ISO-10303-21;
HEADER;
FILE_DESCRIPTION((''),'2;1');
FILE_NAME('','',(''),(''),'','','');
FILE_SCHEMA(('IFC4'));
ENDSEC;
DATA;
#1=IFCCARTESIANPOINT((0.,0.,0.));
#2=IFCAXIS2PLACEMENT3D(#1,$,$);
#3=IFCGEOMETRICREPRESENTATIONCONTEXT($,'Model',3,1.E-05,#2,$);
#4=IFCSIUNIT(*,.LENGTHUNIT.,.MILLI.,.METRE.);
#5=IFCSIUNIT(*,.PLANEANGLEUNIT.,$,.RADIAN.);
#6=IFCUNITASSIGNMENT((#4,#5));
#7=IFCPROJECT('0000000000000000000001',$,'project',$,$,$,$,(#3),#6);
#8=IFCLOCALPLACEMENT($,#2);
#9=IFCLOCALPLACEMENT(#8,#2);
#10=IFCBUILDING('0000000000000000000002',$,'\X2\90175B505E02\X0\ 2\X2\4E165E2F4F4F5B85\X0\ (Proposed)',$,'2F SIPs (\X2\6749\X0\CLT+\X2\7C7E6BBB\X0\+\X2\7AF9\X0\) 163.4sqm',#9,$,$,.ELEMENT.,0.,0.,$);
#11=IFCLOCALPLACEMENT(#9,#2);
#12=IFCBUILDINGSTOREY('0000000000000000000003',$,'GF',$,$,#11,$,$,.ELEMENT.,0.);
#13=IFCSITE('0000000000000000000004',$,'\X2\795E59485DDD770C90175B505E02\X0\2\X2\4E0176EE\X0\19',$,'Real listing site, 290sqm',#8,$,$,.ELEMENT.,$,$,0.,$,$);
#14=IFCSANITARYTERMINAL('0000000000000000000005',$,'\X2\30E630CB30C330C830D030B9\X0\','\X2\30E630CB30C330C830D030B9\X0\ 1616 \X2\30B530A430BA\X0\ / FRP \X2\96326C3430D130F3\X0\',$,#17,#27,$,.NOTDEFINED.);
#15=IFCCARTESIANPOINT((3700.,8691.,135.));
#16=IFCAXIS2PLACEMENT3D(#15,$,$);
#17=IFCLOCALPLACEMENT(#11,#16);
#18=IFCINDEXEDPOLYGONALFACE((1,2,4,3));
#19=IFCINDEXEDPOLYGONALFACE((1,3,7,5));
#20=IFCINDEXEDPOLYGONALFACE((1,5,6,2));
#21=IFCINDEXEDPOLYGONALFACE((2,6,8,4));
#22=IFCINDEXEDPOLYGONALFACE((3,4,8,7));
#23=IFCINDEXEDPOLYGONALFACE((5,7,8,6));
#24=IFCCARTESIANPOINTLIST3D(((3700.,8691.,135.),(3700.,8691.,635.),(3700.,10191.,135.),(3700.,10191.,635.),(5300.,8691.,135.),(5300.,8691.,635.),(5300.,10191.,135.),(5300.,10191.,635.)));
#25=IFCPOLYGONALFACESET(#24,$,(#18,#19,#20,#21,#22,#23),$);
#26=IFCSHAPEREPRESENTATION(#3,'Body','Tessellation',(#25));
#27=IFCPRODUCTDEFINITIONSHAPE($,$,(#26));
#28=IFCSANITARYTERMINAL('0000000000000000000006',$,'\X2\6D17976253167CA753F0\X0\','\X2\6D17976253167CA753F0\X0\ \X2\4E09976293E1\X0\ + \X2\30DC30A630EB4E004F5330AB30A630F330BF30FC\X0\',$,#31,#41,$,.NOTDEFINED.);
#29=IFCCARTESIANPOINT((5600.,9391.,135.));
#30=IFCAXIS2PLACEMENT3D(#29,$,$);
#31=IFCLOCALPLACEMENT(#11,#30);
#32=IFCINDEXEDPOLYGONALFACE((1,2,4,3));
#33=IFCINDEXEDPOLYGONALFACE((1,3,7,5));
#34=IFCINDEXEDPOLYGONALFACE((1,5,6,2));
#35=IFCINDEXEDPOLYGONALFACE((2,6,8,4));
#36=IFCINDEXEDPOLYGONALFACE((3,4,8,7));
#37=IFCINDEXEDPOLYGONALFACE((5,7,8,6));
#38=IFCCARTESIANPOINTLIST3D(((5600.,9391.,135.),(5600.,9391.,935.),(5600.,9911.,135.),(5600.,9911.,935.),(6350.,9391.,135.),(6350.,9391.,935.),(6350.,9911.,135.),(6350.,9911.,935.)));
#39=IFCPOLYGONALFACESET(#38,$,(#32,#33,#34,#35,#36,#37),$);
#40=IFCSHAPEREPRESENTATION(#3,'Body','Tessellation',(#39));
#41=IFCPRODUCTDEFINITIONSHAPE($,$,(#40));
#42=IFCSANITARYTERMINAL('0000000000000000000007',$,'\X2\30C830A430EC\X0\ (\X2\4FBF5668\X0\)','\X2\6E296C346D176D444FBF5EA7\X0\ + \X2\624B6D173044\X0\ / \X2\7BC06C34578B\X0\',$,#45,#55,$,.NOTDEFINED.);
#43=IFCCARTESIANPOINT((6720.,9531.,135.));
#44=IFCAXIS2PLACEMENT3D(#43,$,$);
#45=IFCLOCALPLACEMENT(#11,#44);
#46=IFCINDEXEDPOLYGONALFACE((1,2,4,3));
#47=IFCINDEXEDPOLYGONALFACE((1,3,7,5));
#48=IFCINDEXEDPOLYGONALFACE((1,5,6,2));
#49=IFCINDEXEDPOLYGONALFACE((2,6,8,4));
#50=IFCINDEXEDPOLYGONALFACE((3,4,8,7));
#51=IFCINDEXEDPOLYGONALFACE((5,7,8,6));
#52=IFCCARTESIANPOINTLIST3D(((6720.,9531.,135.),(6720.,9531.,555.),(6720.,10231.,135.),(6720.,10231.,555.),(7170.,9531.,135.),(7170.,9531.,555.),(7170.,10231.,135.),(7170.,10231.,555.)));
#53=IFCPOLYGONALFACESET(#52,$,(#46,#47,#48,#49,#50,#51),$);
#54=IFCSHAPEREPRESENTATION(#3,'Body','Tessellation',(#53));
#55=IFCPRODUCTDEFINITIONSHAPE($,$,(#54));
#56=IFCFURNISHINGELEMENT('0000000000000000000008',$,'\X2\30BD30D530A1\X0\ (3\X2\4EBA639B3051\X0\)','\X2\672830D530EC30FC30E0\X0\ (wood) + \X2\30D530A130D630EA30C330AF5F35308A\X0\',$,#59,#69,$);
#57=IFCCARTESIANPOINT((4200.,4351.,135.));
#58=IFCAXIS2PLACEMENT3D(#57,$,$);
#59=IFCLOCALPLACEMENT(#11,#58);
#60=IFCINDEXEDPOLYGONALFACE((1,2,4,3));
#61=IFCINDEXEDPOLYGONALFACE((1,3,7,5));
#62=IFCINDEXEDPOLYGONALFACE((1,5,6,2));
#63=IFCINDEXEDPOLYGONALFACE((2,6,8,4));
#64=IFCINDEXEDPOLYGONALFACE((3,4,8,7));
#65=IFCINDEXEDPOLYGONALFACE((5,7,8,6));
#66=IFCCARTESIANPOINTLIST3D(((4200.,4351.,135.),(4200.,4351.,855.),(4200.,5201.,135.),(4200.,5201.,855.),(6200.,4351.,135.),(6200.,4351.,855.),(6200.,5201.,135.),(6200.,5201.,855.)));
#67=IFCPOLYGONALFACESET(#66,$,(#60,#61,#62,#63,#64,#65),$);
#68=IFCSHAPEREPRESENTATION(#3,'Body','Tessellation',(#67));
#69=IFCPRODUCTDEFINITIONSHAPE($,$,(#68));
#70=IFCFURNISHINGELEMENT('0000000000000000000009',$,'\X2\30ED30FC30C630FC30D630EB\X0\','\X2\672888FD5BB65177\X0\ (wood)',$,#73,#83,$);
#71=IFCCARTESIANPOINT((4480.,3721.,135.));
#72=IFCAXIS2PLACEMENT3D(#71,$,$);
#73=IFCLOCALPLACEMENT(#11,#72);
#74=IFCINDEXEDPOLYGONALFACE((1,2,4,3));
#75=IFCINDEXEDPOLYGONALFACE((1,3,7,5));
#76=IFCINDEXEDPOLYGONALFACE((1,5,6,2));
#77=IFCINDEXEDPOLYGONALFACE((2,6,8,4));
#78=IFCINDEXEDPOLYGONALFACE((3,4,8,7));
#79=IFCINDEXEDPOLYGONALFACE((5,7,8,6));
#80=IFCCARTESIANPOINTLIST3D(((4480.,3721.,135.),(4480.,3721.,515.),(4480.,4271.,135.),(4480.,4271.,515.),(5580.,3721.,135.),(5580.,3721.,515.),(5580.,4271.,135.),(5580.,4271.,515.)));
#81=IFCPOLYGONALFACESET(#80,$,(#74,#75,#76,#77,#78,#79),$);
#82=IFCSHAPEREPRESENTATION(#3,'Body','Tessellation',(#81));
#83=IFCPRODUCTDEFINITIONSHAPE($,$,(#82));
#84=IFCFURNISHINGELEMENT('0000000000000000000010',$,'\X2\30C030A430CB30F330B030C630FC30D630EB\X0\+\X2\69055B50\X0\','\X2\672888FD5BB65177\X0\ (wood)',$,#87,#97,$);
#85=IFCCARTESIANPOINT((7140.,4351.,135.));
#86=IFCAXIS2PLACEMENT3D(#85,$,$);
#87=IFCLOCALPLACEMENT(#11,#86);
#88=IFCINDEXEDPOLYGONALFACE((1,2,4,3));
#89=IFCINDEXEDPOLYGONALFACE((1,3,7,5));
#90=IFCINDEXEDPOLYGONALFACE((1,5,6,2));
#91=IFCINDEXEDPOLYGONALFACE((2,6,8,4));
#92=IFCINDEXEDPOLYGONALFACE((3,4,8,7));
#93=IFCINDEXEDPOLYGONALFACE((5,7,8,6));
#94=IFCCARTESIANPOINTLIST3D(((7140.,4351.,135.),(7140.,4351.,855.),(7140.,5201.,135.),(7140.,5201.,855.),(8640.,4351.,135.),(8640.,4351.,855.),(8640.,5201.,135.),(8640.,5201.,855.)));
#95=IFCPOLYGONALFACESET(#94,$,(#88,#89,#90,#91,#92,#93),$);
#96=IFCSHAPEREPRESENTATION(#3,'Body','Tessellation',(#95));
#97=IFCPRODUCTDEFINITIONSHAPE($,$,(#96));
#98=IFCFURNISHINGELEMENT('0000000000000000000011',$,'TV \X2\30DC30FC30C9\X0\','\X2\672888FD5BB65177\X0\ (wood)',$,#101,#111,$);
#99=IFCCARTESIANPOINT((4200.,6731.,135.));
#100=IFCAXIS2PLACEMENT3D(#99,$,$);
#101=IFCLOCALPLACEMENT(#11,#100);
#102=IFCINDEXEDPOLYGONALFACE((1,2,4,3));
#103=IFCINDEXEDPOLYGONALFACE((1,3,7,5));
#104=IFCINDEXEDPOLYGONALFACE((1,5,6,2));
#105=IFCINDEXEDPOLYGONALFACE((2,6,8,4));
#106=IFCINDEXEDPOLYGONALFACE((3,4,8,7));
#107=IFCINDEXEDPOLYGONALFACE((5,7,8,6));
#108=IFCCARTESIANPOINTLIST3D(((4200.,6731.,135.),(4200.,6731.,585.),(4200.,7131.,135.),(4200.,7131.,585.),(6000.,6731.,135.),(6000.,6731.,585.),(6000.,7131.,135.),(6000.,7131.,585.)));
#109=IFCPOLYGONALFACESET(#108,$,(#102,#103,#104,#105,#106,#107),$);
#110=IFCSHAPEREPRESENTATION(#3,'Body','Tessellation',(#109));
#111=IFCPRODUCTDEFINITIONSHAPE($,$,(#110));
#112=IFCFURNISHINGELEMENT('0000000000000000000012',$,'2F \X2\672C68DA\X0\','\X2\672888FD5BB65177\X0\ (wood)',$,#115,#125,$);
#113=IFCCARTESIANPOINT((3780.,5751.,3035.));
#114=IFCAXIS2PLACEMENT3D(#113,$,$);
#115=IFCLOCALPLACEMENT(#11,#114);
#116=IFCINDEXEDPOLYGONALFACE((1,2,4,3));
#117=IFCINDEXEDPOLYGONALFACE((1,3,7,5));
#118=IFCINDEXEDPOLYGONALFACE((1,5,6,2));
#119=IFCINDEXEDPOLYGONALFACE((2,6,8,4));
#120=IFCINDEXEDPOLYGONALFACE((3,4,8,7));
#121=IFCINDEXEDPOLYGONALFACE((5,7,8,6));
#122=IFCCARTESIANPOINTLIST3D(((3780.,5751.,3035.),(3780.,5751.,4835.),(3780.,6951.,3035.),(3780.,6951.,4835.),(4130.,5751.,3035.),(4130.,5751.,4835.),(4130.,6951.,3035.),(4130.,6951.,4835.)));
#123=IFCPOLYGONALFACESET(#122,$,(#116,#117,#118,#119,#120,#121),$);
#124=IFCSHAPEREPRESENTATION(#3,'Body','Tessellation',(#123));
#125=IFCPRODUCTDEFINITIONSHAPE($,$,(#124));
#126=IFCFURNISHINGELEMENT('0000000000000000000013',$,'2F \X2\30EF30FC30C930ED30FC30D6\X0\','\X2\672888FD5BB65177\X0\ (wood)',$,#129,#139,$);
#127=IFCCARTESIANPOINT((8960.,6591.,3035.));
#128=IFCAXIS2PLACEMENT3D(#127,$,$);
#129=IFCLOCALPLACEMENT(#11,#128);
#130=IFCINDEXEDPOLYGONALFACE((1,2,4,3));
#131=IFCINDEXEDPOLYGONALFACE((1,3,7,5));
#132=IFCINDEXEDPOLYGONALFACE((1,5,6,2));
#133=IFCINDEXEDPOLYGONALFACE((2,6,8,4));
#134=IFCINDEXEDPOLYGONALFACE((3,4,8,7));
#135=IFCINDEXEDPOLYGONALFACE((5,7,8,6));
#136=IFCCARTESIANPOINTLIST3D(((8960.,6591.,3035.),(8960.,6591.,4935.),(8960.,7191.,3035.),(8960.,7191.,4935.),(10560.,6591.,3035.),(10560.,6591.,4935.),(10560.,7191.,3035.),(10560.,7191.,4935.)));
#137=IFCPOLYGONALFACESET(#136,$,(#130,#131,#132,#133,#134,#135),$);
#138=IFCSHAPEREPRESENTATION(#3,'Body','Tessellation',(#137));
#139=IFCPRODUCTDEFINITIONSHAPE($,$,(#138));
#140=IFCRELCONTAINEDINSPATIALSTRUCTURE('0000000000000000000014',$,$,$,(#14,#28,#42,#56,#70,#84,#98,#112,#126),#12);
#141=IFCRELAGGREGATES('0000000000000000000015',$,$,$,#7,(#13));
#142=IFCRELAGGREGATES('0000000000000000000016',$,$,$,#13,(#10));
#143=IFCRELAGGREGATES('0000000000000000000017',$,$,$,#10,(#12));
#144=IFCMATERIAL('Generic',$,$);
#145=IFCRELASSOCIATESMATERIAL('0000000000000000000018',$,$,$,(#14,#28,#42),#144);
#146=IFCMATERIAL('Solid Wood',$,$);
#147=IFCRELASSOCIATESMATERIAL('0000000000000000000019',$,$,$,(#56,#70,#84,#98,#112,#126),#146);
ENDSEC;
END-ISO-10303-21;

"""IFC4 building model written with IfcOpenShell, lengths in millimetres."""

from ifc_helpers import new_model, si_unit, frame, frame_2d, origin, place, context, project, spatial, rectangle, extrude, material, element, save


model = new_model("IFC4")

# Units and contexts
model_context = context("Model", 3, precision=1e-05, world=origin())
ifc_project = project(units=[si_unit("LENGTHUNIT", "METRE", prefix="MILLI"), si_unit("PLANEANGLEUNIT", "RADIAN")], contexts=[model_context])

# Site, building, storey
site_placement = place(None, origin())
site = spatial("IfcSite", under=ifc_project, at=site_placement, Name="神奈川県逗子市2丁目19", ObjectType="Real listing site, 290sqm", CompositionType="ELEMENT", RefElevation=0.0)
building_placement = place(site_placement, origin())
building = spatial("IfcBuilding", under=site, at=building_placement, Name="逗子市 2世帯住宅 (Proposed)", ObjectType="2F SIPs (杉CLT+籾殻+竹) 163.4sqm", CompositionType="ELEMENT", ElevationOfRefHeight=0.0, ElevationOfTerrain=0.0)
storey_placement = place(building_placement, origin())
storey = spatial("IfcBuildingStorey", under=building, at=storey_placement, Name="GF", CompositionType="ELEMENT", Elevation=0.0)

# Shared definitions
ifc_material_1 = material(Name="Generic")

# Shared definitions
ifc_material_2 = material(Name="Solid Wood")

# Sanitary terminals
sanitary_terminal_1_placement = place(storey_placement, frame((3700.0, 8691.0, 135.0)))
element("IfcSanitaryTerminal", 1, at=sanitary_terminal_1_placement, inside=storey, material=ifc_material_1, Name="ユニットバス", Description="ユニットバス 1616 サイズ / FRP 防水パン", PredefinedType="NOTDEFINED", context=model_context, shape_type="SweptSolid", body=[
    extrude(rectangle(XDim=1600.0, YDim=1500.0, at=frame_2d((800.0, 750.0))), frame((3700.0, 8691.0, 135.0)), (0.0, 0.0, 1.0), 500.0),
])
sanitary_terminal_2_placement = place(storey_placement, frame((5600.0, 9391.0, 135.0)))
element("IfcSanitaryTerminal", 2, at=sanitary_terminal_2_placement, inside=storey, material=ifc_material_1, Name="洗面化粧台", Description="洗面化粧台 三面鏡 + ボウル一体カウンター", PredefinedType="NOTDEFINED", context=model_context, shape_type="SweptSolid", body=[
    extrude(rectangle(XDim=750.0, YDim=520.0, at=frame_2d((375.0, 260.0))), frame((5600.0, 9391.0, 135.0)), (0.0, 0.0, 1.0), 800.0),
])
sanitary_terminal_3_placement = place(storey_placement, frame((6720.0, 9531.0, 135.0)))
element("IfcSanitaryTerminal", 3, at=sanitary_terminal_3_placement, inside=storey, material=ifc_material_1, Name="トイレ (便器)", Description="温水洗浄便座 + 手洗い / 節水型", PredefinedType="NOTDEFINED", context=model_context, shape_type="SweptSolid", body=[
    extrude(rectangle(XDim=450.0, YDim=700.0, at=frame_2d((225.0, 350.0))), frame((6720.0, 9531.0, 135.0)), (0.0, 0.0, 1.0), 420.0),
])

# Furnishing elements
furnishing_1_placement = place(storey_placement, frame((4200.0, 4351.0, 135.0)))
element("IfcFurnishingElement", 4, at=furnishing_1_placement, inside=storey, material=ifc_material_2, Name="ソファ (3人掛け)", Description="木フレーム (wood) + ファブリック張り", context=model_context, shape_type="SweptSolid", body=[
    extrude(rectangle(XDim=2000.0, YDim=850.0, at=frame_2d((1000.0, 425.0))), frame((4200.0, 4351.0, 135.0)), (0.0, 0.0, 1.0), 720.0),
])
furnishing_2_placement = place(storey_placement, frame((4480.0, 3721.0, 135.0)))
element("IfcFurnishingElement", 5, at=furnishing_2_placement, inside=storey, material=ifc_material_2, Name="ローテーブル", Description="木製家具 (wood)", context=model_context, shape_type="SweptSolid", body=[
    extrude(rectangle(XDim=1100.0, YDim=550.0, at=frame_2d((550.0, 275.0))), frame((4480.0, 3721.0, 135.0)), (0.0, 0.0, 1.0), 380.0),
])
furnishing_3_placement = place(storey_placement, frame((7140.0, 4351.0, 135.0)))
element("IfcFurnishingElement", 6, at=furnishing_3_placement, inside=storey, material=ifc_material_2, Name="ダイニングテーブル+椅子", Description="木製家具 (wood)", context=model_context, shape_type="SweptSolid", body=[
    extrude(rectangle(XDim=1500.0, YDim=850.0, at=frame_2d((750.0, 425.0))), frame((7140.0, 4351.0, 135.0)), (0.0, 0.0, 1.0), 720.0),
])
furnishing_4_placement = place(storey_placement, frame((4200.0, 6731.0, 135.0)))
element("IfcFurnishingElement", 7, at=furnishing_4_placement, inside=storey, material=ifc_material_2, Name="TV ボード", Description="木製家具 (wood)", context=model_context, shape_type="SweptSolid", body=[
    extrude(rectangle(XDim=1800.0, YDim=400.0, at=frame_2d((900.0, 200.0))), frame((4200.0, 6731.0, 135.0)), (0.0, 0.0, 1.0), 450.0),
])
furnishing_5_placement = place(storey_placement, frame((3780.0, 5751.0, 3035.0)))
element("IfcFurnishingElement", 8, at=furnishing_5_placement, inside=storey, material=ifc_material_2, Name="2F 本棚", Description="木製家具 (wood)", context=model_context, shape_type="SweptSolid", body=[
    extrude(rectangle(XDim=350.0, YDim=1200.0, at=frame_2d((175.0, 600.0))), frame((3780.0, 5751.0, 3035.0)), (0.0, 0.0, 1.0), 1800.0),
])
furnishing_6_placement = place(storey_placement, frame((8960.0, 6591.0, 3035.0)))
element("IfcFurnishingElement", 9, at=furnishing_6_placement, inside=storey, material=ifc_material_2, Name="2F ワードローブ", Description="木製家具 (wood)", context=model_context, shape_type="SweptSolid", body=[
    extrude(rectangle(XDim=1600.0, YDim=600.0, at=frame_2d((800.0, 300.0))), frame((8960.0, 6591.0, 3035.0)), (0.0, 0.0, 1.0), 1900.0),
])

save(model, "model.ifc")
